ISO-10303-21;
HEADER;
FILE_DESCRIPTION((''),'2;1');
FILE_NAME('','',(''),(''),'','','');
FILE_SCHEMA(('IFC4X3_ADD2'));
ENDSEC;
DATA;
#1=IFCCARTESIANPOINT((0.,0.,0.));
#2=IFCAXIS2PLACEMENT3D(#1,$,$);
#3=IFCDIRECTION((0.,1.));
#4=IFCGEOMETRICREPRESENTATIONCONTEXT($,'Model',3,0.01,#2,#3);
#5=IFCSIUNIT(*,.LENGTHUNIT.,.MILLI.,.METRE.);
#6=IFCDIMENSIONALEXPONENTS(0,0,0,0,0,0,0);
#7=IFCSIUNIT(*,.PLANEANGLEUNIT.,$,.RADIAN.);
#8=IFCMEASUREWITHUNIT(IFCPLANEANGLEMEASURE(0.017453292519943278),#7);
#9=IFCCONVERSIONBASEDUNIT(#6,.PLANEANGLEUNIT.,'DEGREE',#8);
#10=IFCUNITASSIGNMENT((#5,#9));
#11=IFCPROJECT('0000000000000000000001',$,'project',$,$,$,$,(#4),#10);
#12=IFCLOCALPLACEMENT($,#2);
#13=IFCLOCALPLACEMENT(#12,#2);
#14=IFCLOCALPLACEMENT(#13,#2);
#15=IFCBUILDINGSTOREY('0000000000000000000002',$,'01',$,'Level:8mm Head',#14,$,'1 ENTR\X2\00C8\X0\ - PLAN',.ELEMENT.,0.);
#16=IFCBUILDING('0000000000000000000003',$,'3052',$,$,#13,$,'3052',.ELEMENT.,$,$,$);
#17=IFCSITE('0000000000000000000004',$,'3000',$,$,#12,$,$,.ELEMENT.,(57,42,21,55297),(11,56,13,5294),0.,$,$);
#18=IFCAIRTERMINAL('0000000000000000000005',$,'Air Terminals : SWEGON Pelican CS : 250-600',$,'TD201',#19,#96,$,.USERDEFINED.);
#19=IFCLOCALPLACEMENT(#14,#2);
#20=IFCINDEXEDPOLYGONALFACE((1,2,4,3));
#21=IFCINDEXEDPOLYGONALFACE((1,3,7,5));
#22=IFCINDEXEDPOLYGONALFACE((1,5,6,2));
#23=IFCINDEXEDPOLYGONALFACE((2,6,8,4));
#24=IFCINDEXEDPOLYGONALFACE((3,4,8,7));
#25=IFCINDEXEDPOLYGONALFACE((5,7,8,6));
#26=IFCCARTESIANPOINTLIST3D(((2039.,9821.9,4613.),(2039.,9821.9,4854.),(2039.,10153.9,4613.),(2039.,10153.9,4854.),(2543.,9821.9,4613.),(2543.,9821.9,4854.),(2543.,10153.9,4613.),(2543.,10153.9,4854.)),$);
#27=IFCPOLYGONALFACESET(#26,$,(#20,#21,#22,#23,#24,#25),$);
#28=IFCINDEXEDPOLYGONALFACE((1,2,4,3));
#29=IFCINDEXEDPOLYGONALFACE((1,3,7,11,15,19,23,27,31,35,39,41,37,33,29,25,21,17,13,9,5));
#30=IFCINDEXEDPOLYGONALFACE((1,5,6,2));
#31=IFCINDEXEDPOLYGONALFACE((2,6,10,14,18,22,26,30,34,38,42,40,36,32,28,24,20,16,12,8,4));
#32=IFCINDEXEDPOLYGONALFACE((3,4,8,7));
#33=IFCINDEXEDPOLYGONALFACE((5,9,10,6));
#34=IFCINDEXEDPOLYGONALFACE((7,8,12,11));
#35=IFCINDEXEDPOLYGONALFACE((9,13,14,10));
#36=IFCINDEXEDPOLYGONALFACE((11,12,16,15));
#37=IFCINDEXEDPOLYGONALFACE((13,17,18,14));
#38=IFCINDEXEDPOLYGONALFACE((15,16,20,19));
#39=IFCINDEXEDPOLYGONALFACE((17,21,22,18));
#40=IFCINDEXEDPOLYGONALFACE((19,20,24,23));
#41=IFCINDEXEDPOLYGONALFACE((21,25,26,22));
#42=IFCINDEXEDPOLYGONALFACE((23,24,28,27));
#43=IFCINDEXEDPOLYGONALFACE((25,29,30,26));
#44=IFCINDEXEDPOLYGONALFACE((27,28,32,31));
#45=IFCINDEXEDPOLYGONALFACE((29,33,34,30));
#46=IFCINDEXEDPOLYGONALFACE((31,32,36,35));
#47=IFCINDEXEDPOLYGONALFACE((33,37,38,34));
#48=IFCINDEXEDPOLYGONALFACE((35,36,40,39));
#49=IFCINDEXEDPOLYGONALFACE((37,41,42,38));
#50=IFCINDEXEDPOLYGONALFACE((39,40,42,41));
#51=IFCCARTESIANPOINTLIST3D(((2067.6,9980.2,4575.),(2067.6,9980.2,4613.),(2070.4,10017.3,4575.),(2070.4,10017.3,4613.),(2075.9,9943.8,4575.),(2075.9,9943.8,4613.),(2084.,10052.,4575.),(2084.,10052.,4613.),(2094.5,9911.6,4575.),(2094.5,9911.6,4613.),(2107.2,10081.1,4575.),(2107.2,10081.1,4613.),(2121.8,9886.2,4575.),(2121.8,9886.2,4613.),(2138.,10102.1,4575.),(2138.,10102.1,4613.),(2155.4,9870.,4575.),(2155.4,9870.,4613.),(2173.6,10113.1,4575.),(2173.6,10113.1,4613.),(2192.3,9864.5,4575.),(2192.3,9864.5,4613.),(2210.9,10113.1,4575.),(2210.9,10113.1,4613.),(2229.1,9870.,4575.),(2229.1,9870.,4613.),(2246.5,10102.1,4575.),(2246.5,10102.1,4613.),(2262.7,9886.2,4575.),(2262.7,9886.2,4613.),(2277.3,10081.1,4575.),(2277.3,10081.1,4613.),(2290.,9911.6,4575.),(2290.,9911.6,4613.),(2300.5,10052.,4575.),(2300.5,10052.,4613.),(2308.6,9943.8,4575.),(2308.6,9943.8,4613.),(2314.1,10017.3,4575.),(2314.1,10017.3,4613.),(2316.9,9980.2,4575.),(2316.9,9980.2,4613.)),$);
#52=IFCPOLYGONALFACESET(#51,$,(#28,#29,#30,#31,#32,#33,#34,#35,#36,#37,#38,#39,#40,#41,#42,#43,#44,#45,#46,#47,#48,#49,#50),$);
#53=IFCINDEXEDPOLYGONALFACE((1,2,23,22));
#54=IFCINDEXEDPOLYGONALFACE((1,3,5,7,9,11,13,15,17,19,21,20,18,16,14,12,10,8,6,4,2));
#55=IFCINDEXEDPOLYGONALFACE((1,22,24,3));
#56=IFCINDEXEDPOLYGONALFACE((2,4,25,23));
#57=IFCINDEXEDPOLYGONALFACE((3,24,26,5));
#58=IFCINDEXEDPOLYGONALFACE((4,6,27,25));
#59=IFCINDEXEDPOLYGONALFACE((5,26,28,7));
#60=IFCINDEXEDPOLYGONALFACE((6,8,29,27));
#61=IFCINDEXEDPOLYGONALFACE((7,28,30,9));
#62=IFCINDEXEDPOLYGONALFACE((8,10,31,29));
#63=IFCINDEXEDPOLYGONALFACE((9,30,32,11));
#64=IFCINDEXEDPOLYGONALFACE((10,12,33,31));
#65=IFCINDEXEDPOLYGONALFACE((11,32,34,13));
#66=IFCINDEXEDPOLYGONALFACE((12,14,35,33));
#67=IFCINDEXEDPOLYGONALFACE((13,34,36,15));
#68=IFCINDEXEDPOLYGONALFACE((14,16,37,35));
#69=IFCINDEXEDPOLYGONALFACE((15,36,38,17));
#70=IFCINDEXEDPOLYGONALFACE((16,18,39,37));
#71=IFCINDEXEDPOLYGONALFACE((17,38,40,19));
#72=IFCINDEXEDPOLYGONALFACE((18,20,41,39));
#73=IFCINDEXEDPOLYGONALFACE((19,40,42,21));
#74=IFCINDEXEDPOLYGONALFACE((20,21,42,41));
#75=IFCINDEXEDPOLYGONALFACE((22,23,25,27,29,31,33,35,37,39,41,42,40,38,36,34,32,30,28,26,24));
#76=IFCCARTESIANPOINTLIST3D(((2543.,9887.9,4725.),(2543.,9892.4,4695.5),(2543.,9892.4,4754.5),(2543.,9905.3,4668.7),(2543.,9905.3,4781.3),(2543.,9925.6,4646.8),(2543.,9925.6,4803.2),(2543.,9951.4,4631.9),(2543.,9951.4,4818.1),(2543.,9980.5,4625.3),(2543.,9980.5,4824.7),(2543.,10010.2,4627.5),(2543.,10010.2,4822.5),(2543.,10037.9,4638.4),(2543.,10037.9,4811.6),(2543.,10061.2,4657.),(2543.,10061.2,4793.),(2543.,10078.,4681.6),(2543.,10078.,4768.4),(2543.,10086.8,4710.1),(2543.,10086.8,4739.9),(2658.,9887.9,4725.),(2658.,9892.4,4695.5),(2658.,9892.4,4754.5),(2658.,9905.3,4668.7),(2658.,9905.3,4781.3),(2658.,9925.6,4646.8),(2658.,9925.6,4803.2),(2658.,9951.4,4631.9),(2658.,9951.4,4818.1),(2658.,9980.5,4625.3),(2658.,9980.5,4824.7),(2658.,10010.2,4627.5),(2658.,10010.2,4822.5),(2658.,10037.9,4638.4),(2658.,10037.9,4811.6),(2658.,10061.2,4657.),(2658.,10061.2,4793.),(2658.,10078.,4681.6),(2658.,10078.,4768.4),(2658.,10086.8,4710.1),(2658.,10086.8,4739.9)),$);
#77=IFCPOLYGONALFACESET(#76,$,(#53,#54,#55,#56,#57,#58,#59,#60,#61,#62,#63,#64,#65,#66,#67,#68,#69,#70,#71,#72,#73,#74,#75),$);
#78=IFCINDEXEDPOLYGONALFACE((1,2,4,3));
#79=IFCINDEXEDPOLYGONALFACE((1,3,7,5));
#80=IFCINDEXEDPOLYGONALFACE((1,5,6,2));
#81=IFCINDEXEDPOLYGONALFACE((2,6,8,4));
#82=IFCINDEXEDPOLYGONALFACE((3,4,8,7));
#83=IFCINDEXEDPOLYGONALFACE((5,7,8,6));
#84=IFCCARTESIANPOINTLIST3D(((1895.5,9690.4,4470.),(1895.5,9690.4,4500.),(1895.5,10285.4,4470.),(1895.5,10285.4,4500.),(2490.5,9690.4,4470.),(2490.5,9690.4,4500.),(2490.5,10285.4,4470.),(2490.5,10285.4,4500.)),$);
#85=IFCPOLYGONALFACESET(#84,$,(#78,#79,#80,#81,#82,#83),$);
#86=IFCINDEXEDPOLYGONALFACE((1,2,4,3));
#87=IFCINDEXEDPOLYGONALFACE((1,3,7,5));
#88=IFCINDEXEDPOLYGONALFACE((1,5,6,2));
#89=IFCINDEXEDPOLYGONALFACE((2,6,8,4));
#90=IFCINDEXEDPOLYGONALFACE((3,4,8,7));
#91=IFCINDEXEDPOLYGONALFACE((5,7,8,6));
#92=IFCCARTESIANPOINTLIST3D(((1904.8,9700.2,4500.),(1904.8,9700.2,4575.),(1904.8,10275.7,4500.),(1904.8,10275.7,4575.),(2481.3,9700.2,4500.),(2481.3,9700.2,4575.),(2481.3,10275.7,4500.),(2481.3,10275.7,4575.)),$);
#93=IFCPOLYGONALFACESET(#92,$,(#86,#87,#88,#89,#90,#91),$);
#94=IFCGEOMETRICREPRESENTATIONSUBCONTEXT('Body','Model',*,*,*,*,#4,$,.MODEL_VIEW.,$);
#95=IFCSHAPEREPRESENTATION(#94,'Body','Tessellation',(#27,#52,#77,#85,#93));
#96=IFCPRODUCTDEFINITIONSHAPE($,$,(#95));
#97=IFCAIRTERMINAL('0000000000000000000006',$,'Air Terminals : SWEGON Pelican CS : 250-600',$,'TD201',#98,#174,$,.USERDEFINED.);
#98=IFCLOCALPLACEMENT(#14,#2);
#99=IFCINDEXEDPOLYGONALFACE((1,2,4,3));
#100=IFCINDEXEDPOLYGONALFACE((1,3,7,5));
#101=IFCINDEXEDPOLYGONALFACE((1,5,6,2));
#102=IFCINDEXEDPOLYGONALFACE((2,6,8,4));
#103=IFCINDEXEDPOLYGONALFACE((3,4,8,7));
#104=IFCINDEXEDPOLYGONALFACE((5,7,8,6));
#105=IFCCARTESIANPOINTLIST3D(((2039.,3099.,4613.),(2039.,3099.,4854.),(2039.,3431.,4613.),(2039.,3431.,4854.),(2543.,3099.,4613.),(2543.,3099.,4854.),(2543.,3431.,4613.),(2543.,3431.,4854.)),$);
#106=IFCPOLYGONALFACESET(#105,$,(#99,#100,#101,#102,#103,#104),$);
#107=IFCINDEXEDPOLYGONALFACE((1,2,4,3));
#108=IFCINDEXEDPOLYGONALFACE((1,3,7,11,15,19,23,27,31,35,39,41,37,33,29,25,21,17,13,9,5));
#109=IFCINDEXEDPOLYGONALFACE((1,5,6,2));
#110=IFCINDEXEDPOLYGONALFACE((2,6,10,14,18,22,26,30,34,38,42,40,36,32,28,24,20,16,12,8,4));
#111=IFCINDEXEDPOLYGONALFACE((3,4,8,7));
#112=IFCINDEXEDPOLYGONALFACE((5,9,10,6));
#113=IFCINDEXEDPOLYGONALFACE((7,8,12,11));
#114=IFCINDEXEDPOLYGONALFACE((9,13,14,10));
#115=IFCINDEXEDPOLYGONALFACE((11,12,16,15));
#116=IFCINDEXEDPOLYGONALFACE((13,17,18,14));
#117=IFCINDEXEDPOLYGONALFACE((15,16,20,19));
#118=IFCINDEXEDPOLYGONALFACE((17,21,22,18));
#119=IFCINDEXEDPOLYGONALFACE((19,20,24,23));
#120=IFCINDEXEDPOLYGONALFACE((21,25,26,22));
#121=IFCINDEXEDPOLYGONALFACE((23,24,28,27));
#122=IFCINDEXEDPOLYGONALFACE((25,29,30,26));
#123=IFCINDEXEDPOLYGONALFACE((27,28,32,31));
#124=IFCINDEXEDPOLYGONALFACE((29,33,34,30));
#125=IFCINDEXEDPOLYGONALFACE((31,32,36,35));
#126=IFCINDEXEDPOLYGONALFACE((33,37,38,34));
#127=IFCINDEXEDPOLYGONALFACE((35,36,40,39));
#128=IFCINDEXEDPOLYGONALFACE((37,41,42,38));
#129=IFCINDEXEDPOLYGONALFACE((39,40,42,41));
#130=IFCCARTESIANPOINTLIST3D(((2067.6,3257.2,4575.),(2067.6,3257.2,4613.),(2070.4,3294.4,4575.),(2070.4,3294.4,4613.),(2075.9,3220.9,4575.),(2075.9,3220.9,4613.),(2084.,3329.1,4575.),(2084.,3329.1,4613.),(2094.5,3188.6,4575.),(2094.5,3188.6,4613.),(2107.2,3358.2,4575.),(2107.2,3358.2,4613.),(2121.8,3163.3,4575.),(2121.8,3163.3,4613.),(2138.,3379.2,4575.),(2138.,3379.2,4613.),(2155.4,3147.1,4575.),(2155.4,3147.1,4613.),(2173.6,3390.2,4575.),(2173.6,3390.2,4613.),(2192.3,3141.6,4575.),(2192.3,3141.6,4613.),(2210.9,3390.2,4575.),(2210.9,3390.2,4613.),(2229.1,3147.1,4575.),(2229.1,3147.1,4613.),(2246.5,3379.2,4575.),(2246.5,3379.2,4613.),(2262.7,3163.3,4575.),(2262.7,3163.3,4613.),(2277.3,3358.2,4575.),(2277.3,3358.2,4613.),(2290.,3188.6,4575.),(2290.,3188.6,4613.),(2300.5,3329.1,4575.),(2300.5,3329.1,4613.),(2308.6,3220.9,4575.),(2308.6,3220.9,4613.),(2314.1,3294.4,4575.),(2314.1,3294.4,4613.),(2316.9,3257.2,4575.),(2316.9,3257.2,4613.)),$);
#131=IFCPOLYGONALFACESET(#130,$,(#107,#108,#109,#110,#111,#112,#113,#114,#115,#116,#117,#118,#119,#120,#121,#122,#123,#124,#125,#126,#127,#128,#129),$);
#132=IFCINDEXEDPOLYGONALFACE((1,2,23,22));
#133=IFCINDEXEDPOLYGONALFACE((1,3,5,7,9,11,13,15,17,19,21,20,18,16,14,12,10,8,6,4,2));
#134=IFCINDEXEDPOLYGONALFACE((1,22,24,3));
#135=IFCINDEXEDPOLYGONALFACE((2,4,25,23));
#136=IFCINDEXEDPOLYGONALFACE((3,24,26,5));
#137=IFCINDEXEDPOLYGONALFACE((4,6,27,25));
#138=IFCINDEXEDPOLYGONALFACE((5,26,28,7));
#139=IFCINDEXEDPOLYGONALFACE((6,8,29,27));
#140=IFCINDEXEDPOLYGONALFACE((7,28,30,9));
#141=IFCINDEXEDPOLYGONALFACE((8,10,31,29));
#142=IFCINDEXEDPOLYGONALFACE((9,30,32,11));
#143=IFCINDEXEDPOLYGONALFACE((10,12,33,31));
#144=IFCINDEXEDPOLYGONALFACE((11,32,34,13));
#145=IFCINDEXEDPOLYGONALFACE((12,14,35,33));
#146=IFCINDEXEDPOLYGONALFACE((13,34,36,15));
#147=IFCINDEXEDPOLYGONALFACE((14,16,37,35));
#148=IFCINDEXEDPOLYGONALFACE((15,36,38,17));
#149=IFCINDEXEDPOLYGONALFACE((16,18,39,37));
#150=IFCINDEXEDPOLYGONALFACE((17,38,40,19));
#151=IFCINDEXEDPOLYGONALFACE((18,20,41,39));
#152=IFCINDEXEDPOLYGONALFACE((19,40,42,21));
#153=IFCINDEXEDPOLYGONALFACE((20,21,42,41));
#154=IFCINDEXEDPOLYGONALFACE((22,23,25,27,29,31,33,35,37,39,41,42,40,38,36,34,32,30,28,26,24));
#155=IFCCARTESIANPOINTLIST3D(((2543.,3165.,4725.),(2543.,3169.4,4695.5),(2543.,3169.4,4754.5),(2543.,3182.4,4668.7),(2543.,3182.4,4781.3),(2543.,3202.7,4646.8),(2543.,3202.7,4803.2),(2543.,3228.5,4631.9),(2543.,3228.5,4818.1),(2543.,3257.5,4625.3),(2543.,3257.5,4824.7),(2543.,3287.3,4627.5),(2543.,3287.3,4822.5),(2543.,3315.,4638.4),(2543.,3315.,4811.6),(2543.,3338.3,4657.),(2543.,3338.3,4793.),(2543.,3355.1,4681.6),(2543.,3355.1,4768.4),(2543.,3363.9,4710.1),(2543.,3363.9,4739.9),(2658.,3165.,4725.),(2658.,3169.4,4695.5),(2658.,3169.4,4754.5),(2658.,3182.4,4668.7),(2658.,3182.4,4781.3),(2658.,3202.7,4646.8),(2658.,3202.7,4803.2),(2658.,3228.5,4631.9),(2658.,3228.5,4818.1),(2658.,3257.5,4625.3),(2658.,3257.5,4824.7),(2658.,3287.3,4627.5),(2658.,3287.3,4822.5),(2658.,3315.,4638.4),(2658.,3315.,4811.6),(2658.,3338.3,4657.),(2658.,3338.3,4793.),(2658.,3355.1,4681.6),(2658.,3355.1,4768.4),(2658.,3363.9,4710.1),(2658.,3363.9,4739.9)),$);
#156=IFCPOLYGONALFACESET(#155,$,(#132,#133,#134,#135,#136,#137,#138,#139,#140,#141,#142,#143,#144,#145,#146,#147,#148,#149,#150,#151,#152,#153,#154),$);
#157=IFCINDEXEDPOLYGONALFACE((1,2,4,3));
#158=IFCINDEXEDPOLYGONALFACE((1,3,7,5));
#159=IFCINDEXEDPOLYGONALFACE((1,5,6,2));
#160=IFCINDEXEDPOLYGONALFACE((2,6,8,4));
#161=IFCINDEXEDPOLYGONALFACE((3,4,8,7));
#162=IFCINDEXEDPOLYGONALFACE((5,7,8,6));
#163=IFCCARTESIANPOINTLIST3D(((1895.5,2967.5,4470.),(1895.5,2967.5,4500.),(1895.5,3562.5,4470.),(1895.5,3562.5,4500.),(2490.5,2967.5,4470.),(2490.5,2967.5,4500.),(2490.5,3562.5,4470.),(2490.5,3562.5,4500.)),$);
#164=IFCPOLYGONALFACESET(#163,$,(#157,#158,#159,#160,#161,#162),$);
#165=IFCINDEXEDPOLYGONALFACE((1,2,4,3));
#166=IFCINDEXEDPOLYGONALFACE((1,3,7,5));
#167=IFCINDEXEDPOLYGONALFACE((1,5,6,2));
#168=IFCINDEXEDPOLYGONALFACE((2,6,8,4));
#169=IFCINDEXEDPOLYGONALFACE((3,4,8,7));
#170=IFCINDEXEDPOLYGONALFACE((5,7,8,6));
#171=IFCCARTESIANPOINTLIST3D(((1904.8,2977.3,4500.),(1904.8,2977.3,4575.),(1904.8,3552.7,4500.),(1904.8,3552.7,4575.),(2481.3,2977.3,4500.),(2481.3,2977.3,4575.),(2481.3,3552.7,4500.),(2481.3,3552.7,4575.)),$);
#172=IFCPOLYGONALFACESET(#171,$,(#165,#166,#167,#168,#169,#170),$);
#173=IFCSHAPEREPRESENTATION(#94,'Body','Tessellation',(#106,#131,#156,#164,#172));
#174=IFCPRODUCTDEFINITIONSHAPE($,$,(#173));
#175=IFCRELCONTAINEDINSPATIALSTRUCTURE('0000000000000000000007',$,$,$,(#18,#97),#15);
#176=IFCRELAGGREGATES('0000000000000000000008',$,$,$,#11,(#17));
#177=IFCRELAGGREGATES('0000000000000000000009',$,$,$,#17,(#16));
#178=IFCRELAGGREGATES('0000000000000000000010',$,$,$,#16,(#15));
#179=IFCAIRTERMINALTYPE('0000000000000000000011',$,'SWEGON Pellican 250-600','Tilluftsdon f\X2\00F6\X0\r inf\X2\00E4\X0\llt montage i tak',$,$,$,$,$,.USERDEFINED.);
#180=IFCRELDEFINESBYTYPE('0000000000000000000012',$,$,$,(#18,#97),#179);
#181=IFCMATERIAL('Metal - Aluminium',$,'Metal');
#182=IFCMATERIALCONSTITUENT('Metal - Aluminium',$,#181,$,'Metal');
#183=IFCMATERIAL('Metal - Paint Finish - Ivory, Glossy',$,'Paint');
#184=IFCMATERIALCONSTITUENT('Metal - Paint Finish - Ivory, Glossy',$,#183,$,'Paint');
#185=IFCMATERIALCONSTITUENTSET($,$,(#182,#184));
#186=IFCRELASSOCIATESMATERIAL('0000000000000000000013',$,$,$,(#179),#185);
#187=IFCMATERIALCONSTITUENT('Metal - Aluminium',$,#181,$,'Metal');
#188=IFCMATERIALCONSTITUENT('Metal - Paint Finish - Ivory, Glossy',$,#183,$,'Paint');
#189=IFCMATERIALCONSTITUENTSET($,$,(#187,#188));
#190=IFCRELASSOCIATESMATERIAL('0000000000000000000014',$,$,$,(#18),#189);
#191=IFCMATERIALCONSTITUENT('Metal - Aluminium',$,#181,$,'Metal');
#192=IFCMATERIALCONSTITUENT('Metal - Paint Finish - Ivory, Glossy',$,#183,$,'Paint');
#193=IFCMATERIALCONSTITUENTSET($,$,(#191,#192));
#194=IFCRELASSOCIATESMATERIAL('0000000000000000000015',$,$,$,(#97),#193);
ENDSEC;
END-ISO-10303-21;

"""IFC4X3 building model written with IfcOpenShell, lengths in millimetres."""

from ifc_helpers import new_model, entity, si_unit, converted_unit, direction, frame, frame_2d, origin, origin_2d_with_axis, place, context, subcontext, project, spatial, rectangle, circle, extrude, source, transform, mapped, material, constituent, constituent_set, type_object, type_shapes, element, save


model = new_model("IFC4X3")

# Units and contexts
model_context = context("Model", 3, precision=0.01, world=origin(), true_north=direction((0.0, 1.0)))
body_context = subcontext(model_context, "Body", "Model", "MODEL_VIEW")
ifc_project = project(units=[si_unit("LENGTHUNIT", "METRE", prefix="MILLI"), converted_unit("PLANEANGLEUNIT", "DEGREE", entity("IfcPlaneAngleMeasure", 0.017453292519943278), si_unit("PLANEANGLEUNIT", "RADIAN"), dimensions=[0, 0, 0, 0, 0, 0, 0])], contexts=[model_context])

# Site, building, storey
site_placement = place(None, origin())
site = spatial("IfcSite", under=ifc_project, at=site_placement, Name="3000", CompositionType="ELEMENT", RefLatitude=(57, 42, 21, 55297), RefLongitude=(11, 56, 13, 5294), RefElevation=0.0)
building_placement = place(site_placement, origin())
building = spatial("IfcBuilding", under=site, at=building_placement, Name="3052", LongName="3052", CompositionType="ELEMENT")
storey_placement = place(building_placement, origin())
storey = spatial("IfcBuildingStorey", under=building, at=storey_placement, Name="01", ObjectType="Level:8mm Head", LongName="1 ENTRÈ - PLAN", CompositionType="ELEMENT", Elevation=0.0)

# Air terminals
ifc_material_1 = material(Name="Metal - Aluminium", Category="Metal")
ifc_material_2 = material(Name="Metal - Paint Finish - Ivory, Glossy", Category="Paint")
ifc_constituent_1 = constituent(ifc_material_1, Name="Metal - Aluminium", Category="Metal")
ifc_constituent_2 = constituent(ifc_material_2, Name="Metal - Paint Finish - Ivory, Glossy", Category="Paint")
ifc_constituent_set_1 = constituent_set(constituents=[ifc_constituent_1, ifc_constituent_2])
ifc_constituent_3 = constituent(ifc_material_1, Name="Metal - Aluminium", Category="Metal")
ifc_constituent_4 = constituent(ifc_material_2, Name="Metal - Paint Finish - Ivory, Glossy", Category="Paint")
ifc_constituent_set_2 = constituent_set(constituents=[ifc_constituent_3, ifc_constituent_4])
air_terminal_type_1 = type_object("IfcAirTerminalType", Name="SWEGON Pellican 250-600", Description="Tilluftsdon för infällt montage i tak", PredefinedType="USERDEFINED", material=ifc_constituent_set_2)
shared_shape_1 = source(origin(), body_context, "Body", "SweptSolid", [
    extrude(rectangle(XDim=504.0, YDim=332.0, at=origin_2d_with_axis()), frame((0.0, -98.0, -354.0), z_axis=(0.0, 0.0, 1.0), x_axis=(0.0, 1.0, 0.0)), (0.0, 0.0, 1.0), 241.0),
    extrude(circle(Radius=125.0, at=frame_2d((0.0, 0.0), x_axis=(1.0, 0.0))), frame((-1.6, 0.8, -113.0)), (0.0, 0.0, 1.0), 38.0),
    extrude(circle(Radius=100.0, at=frame_2d((0.0, 0.0), x_axis=(1.0, 0.0))), frame((0.0, -465.0, -225.0), z_axis=(0.0, 1.0, 0.0), x_axis=(1.0, 0.0, 0.0)), (0.0, 0.0, 1.0), 115.0),
    extrude(rectangle(XDim=595.0, YDim=595.0, at=frame_2d((0.0, 0.0), x_axis=(1.0, 0.0))), frame((0.0, 0.0, 0.0), z_axis=(0.0, 0.0, 1.0), x_axis=(0.0, 1.0, 0.0)), (0.0, 0.0, 1.0), 30.0),
    extrude(rectangle(XDim=576.5, YDim=575.5, at=origin_2d_with_axis()), frame((0.0, 0.0, -75.0), z_axis=(0.0, 0.0, 1.0), x_axis=(0.0, 1.0, 0.0)), (0.0, 0.0, 1.0), 75.0),
])
type_shapes(air_terminal_type_1, [shared_shape_1])
air_terminal_1_placement = place(storey_placement, frame((2193.0, 9987.9, 4500.0), z_axis=(0.0, 0.0, -1.0), x_axis=(0.0, -1.0, 0.0)))
element("IfcAirTerminal", 1, at=air_terminal_1_placement, inside=storey, type_object=air_terminal_type_1, material=ifc_constituent_set_1, Name="Air Terminals : SWEGON Pelican CS : 250-600", ObjectType="TD201", PredefinedType="USERDEFINED", context=body_context, shape_type="MappedRepresentation", body=[
    mapped(shared_shape_1, transform((0.0, 0.0, 0.0), scale=1.0)),
])
ifc_constituent_5 = constituent(ifc_material_1, Name="Metal - Aluminium", Category="Metal")
ifc_constituent_6 = constituent(ifc_material_2, Name="Metal - Paint Finish - Ivory, Glossy", Category="Paint")
ifc_constituent_set_3 = constituent_set(constituents=[ifc_constituent_5, ifc_constituent_6])
air_terminal_2_placement = place(storey_placement, frame((2193.0, 3265.0, 4500.0), z_axis=(0.0, 0.0, -1.0), x_axis=(0.0, -1.0, 0.0)))
element("IfcAirTerminal", 2, at=air_terminal_2_placement, inside=storey, type_object=air_terminal_type_1, material=ifc_constituent_set_3, Name="Air Terminals : SWEGON Pelican CS : 250-600", ObjectType="TD201", PredefinedType="USERDEFINED", context=body_context, shape_type="MappedRepresentation", body=[
    mapped(shared_shape_1, transform((0.0, 0.0, 0.0), scale=1.0)),
])

save(model, "model.ifc")
